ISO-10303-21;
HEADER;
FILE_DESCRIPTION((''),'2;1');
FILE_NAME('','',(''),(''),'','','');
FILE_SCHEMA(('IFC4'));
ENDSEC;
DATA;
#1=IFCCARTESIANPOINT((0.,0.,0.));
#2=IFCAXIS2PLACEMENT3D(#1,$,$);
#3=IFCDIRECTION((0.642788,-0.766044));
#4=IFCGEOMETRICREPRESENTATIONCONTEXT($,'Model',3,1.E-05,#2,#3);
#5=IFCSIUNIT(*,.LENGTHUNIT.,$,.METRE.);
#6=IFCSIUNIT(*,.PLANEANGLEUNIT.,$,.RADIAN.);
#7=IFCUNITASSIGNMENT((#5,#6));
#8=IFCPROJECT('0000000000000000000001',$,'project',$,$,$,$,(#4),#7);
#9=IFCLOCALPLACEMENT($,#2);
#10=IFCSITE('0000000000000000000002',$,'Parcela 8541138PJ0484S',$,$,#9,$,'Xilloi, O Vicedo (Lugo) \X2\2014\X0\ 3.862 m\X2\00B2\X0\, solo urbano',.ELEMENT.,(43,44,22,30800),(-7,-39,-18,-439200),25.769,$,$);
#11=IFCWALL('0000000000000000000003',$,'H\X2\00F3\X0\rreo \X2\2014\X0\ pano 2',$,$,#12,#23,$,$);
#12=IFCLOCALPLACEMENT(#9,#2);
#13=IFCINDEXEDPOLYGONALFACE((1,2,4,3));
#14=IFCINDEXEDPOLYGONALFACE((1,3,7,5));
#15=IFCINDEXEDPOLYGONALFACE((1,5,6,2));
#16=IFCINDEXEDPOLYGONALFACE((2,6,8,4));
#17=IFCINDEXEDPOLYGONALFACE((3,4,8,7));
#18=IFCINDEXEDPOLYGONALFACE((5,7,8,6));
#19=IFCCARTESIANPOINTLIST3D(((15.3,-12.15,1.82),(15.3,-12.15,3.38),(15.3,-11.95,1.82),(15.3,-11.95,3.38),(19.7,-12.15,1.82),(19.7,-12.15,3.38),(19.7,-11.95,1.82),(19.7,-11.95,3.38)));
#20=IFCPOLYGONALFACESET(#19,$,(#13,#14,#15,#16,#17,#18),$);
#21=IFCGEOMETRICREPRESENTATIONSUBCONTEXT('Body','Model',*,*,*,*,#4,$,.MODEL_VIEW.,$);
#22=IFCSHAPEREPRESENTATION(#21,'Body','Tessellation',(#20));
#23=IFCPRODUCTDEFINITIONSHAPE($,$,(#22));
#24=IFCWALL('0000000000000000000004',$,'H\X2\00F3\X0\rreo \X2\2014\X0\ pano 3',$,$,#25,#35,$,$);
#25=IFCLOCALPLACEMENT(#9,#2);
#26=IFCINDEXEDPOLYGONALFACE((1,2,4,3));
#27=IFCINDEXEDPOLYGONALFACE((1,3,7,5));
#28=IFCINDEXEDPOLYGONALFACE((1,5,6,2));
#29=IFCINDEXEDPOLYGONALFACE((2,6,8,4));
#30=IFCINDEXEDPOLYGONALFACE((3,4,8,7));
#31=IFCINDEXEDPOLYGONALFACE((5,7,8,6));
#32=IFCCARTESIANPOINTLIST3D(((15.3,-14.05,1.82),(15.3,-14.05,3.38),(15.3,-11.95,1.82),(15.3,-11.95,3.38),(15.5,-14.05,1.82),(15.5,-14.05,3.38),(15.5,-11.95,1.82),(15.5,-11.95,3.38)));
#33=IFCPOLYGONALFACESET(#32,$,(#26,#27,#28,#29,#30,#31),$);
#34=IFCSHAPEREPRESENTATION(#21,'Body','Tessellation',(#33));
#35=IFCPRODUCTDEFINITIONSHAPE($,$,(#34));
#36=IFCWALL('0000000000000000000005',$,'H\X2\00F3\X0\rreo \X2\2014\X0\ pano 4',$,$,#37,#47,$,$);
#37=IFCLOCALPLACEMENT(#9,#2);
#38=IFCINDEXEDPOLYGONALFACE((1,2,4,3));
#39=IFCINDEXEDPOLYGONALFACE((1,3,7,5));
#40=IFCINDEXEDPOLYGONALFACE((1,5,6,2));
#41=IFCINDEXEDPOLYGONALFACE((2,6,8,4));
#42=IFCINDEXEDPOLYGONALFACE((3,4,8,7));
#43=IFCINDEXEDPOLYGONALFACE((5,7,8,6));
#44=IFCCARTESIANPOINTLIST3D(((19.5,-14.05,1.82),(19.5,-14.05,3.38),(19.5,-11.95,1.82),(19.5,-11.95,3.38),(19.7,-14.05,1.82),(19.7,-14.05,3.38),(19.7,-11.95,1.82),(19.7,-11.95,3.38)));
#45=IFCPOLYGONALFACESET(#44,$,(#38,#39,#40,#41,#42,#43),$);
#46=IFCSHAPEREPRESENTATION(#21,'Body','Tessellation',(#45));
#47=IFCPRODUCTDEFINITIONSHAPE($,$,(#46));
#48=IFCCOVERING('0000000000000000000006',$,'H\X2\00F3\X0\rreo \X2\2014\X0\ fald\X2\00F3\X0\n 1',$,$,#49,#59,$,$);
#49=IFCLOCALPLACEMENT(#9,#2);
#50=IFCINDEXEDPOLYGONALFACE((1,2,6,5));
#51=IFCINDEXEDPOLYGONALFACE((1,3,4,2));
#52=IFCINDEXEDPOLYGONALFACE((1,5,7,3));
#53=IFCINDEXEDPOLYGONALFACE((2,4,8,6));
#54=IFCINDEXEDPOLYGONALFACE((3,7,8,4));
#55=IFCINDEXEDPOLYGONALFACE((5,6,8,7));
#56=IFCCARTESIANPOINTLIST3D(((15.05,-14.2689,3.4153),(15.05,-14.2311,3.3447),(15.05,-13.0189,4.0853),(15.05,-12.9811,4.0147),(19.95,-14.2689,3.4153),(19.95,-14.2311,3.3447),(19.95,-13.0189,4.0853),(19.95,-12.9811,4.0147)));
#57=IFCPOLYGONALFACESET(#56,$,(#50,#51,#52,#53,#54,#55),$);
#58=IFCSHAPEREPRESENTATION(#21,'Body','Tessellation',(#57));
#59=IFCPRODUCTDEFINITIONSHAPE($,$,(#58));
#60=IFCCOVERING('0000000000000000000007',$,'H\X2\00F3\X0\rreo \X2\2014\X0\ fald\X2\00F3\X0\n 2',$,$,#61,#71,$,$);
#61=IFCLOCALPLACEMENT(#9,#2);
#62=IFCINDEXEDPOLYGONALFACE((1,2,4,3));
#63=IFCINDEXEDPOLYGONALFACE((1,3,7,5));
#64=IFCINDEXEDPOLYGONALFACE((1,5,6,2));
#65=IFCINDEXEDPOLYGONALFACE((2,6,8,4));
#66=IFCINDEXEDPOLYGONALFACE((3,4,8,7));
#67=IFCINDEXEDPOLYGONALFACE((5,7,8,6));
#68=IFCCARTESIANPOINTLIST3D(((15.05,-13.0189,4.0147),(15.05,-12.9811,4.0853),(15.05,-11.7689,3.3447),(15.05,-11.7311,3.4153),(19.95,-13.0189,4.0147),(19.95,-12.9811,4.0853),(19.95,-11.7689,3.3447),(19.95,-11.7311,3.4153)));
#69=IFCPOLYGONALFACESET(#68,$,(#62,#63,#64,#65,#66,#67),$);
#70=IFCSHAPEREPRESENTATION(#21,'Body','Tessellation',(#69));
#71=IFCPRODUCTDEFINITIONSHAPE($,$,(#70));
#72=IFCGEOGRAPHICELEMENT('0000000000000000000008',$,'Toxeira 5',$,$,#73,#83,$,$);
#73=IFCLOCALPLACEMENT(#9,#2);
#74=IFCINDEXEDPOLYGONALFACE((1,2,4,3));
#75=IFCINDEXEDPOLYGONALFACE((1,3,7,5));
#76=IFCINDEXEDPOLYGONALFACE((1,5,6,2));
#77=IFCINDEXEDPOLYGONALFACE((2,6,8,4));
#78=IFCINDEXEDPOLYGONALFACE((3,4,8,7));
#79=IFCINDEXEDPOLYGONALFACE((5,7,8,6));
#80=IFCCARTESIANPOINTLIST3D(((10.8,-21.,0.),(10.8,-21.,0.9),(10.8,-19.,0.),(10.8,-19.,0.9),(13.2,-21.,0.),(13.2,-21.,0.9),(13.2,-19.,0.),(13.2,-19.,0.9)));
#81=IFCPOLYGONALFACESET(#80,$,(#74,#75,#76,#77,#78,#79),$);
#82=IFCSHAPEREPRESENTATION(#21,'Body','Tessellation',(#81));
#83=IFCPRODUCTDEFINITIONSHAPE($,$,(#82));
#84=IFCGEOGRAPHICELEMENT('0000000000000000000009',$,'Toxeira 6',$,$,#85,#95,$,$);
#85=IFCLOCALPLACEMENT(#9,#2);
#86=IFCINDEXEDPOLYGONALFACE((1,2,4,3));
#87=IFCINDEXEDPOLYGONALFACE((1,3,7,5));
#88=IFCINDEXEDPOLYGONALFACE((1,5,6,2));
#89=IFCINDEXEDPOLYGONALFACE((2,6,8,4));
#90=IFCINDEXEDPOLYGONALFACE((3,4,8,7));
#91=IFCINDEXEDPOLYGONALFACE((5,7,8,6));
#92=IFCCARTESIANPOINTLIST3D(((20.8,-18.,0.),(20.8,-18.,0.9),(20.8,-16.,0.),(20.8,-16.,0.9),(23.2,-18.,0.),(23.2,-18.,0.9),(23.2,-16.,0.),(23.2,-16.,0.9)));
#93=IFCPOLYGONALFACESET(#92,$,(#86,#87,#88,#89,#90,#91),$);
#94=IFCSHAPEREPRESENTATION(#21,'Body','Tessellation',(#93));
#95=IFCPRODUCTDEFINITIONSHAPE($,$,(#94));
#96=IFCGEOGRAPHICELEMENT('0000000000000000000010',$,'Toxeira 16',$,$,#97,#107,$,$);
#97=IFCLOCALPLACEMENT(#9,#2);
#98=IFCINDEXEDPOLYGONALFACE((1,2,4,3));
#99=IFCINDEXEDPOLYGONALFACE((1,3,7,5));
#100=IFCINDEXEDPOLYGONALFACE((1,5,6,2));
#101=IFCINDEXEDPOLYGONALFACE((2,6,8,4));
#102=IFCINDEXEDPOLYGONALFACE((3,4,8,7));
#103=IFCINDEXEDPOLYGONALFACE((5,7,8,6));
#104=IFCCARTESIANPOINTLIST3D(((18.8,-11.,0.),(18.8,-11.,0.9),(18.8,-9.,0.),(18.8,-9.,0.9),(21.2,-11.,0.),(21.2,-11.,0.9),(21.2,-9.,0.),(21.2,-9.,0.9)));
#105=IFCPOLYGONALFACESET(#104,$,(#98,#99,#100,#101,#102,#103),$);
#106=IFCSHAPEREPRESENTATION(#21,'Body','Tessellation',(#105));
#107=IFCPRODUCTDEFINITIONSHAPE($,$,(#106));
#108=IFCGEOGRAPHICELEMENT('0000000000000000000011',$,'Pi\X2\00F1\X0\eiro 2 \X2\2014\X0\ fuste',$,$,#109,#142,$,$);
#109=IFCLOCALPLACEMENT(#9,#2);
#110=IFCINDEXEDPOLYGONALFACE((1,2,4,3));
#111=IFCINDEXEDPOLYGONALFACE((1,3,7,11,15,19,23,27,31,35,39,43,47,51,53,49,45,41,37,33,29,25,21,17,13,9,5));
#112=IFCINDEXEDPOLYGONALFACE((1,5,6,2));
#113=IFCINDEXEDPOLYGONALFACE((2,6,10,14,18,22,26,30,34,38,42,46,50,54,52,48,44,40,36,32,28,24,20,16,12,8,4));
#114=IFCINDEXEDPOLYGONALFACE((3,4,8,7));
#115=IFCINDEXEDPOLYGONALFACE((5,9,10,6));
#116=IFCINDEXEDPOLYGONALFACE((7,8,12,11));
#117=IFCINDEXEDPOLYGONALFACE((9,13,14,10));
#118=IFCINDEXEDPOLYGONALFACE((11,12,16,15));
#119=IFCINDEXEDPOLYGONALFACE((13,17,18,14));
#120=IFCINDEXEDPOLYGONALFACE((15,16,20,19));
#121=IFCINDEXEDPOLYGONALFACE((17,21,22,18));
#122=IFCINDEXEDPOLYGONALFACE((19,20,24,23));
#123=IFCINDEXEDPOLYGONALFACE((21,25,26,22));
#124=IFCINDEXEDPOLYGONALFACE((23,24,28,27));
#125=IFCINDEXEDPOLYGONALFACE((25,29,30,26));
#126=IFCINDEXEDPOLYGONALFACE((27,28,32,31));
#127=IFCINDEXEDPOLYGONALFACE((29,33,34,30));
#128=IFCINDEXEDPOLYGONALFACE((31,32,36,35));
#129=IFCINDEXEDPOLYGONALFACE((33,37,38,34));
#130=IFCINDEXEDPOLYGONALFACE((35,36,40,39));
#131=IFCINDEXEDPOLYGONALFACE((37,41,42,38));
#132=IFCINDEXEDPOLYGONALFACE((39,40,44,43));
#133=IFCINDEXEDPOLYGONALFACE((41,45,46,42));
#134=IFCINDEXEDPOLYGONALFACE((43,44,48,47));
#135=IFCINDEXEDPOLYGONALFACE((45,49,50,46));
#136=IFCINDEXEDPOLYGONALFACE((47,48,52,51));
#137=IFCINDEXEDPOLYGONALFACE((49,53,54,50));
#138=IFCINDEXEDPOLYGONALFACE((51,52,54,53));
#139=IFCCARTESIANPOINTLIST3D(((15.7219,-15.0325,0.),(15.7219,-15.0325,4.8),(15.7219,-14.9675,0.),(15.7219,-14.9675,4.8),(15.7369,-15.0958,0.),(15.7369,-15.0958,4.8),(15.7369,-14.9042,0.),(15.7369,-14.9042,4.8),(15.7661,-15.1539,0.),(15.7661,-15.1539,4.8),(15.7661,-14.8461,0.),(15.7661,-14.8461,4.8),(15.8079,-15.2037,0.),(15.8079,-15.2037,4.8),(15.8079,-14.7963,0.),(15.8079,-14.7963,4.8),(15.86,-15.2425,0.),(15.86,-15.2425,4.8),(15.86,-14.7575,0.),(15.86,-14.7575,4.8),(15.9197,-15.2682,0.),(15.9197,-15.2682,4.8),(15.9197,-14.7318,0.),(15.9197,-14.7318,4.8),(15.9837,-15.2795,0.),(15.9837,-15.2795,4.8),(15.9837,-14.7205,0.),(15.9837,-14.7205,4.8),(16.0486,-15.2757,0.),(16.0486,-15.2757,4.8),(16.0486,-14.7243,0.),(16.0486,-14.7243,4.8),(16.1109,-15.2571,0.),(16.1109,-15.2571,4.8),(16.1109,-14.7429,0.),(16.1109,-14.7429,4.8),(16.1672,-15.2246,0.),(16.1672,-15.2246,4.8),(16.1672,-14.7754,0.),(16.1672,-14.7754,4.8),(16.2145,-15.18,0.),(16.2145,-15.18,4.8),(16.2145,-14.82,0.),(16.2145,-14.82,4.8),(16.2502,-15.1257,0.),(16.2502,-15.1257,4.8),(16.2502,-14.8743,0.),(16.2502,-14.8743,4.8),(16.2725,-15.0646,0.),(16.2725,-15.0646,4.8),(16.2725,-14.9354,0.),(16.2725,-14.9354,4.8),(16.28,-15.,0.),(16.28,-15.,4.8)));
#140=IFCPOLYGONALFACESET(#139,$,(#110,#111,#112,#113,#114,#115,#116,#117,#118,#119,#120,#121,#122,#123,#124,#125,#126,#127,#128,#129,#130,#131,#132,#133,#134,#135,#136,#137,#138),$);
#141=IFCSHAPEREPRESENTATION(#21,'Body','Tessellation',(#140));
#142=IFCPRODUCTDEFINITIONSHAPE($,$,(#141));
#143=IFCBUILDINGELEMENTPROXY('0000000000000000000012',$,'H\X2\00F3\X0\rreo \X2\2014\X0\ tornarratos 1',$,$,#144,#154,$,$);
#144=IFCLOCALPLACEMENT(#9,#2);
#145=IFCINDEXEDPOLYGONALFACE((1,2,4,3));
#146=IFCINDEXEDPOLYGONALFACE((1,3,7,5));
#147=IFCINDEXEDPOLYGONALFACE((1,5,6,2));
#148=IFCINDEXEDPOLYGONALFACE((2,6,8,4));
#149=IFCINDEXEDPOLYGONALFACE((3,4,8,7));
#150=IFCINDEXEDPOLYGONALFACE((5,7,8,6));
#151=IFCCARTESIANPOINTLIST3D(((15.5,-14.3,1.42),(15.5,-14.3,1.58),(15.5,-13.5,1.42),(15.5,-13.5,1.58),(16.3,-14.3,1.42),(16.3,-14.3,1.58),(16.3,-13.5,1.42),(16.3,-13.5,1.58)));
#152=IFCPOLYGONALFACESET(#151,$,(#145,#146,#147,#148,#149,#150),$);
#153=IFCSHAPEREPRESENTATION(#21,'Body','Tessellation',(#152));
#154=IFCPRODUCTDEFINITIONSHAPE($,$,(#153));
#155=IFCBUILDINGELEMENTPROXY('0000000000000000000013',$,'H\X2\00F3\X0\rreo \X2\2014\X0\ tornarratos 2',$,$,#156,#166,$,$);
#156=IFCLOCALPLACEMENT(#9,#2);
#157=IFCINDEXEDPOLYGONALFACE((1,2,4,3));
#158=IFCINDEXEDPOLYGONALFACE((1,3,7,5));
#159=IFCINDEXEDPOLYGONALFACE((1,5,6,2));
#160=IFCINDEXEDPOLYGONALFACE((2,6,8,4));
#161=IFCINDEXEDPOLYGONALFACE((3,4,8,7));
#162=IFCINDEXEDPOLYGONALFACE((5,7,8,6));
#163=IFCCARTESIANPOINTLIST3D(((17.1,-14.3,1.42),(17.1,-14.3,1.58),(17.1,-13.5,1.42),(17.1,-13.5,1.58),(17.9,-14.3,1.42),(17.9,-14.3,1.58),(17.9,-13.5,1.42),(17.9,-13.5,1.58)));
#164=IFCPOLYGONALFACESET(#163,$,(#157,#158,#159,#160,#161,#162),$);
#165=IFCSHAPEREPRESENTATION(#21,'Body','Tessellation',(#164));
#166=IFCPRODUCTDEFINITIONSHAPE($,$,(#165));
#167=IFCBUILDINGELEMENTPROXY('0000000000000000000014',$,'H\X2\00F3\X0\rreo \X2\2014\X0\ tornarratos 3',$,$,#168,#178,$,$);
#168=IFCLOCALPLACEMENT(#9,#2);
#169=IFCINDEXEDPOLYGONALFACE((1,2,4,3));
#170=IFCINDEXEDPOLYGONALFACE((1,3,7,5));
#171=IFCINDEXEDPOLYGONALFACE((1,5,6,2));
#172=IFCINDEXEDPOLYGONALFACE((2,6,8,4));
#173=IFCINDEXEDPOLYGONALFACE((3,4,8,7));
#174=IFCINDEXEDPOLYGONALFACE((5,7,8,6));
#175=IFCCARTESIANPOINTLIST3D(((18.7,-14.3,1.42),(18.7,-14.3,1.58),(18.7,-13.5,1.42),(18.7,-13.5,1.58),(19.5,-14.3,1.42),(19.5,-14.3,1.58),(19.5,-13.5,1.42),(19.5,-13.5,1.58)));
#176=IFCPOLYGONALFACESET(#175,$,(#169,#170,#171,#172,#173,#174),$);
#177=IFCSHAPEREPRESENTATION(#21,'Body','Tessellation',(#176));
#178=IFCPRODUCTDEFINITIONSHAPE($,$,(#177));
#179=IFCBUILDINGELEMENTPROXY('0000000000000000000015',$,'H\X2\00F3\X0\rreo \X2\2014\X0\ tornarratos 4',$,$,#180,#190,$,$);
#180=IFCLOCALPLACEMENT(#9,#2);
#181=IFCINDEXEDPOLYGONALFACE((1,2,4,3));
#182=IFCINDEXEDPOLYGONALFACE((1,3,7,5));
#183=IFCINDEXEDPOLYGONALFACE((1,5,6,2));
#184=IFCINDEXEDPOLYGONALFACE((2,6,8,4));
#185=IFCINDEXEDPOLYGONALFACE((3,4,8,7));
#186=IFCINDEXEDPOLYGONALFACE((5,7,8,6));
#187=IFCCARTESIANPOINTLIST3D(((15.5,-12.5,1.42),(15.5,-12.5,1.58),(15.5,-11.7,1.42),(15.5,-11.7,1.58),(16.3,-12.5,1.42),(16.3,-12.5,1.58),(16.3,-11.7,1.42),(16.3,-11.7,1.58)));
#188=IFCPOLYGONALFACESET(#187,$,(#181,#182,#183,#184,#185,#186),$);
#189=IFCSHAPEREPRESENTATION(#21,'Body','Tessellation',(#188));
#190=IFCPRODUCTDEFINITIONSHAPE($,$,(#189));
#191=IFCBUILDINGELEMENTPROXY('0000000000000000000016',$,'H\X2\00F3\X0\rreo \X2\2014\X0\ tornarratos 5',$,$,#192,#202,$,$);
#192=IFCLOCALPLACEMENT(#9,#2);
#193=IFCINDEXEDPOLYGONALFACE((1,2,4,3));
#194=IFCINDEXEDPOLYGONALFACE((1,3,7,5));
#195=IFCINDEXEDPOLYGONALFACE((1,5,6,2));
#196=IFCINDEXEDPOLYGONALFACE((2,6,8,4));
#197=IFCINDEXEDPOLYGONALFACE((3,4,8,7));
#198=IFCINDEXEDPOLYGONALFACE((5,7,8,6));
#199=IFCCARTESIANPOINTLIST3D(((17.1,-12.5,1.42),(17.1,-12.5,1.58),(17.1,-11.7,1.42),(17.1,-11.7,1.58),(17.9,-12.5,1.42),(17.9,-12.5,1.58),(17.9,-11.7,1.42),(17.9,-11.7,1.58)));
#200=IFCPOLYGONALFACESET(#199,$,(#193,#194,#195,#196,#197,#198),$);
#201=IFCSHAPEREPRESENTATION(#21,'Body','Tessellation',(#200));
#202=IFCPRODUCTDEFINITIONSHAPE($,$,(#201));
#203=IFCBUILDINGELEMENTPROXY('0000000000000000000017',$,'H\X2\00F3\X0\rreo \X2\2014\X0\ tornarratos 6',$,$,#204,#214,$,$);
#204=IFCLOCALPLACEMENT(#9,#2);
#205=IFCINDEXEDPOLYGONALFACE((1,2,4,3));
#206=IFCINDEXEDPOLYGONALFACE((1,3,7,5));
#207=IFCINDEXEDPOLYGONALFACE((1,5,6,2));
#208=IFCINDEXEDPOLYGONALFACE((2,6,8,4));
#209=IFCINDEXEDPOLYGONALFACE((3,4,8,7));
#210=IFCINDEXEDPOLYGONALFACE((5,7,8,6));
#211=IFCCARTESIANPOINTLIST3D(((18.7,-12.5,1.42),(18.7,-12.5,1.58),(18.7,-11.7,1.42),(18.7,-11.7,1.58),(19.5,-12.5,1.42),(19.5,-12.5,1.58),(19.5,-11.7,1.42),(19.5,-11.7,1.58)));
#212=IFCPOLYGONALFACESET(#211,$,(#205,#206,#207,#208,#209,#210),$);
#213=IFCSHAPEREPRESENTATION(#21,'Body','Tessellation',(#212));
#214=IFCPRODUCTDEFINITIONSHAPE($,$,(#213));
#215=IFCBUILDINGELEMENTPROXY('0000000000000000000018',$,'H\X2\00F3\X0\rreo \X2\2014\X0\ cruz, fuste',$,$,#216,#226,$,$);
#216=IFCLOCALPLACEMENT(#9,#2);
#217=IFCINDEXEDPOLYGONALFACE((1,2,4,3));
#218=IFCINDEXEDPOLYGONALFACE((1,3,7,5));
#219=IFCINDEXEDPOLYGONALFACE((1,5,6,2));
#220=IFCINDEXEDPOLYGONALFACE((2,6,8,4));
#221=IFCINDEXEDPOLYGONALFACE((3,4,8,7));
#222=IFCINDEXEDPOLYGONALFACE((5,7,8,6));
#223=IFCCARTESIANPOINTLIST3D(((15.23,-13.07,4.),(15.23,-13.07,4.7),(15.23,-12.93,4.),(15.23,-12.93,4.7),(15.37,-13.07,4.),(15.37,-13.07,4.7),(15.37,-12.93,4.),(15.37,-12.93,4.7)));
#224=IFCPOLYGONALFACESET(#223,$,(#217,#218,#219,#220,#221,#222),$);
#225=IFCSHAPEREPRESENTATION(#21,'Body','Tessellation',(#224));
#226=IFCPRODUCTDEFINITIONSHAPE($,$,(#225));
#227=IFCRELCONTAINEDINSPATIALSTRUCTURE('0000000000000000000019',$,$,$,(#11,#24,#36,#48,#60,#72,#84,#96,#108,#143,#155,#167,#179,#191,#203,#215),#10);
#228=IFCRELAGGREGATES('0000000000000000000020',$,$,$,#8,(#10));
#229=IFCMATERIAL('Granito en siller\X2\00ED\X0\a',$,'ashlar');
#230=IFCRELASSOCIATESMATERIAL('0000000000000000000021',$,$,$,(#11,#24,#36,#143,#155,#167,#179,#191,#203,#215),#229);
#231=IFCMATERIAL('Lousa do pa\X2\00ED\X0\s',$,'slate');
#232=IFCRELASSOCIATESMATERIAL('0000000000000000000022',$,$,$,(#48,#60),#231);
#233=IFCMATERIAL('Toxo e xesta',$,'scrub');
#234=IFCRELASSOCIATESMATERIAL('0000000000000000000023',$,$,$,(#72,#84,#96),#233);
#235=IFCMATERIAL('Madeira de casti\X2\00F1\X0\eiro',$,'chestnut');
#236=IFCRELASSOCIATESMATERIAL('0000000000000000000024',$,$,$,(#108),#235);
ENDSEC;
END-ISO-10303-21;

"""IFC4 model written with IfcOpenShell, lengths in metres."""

from ifc_helpers import new_model, si_unit, direction, frame, origin, origin_2d, place, context, subcontext, project, spatial, polyline, rectangle, circle, outline, extrude, material, element, save


model = new_model("IFC4")

# Units and contexts
model_context = context("Model", 3, precision=1e-05, world=origin(), true_north=direction((0.642788, -0.766044)))
body_context = subcontext(model_context, "Body", "Model", "MODEL_VIEW")
ifc_project = project(units=[si_unit("LENGTHUNIT", "METRE"), si_unit("PLANEANGLEUNIT", "RADIAN")], contexts=[model_context])

# Site
site_placement = place(None, origin())
site = spatial("IfcSite", under=ifc_project, at=site_placement, Name="Parcela 8541138PJ0484S", LongName="Xilloi, O Vicedo (Lugo) — 3.862 m², solo urbano", CompositionType="ELEMENT", RefLatitude=(43, 44, 22, 30800), RefLongitude=(-7, -39, -18, -439200), RefElevation=25.769)

# Shared definitions
ifc_material_1 = material(Name="Granito en sillería", Category="ashlar")

# Shared definitions
ifc_material_2 = material(Name="Madeira de castiñeiro", Category="chestnut")

# Walls
for number, where, name in (
    (1, (17.5, -12.05, 2.6), "Hórreo — pano 2"),
):
    element("IfcWall", number, at=place(site_placement, frame(where)), inside=site, material=ifc_material_1, Name=name, context=body_context, shape_type="SweptSolid", body=[
        extrude(rectangle(XDim=4.4, YDim=0.2, at=origin_2d()), frame((0.0, 0.0, -0.78)), (0.0, 0.0, 1.0), 1.56),
    ])
for number, where, name in (
    (2, (15.4, -13.0, 2.6), "Hórreo — pano 3"),
    (3, (19.6, -13.0, 2.6), "Hórreo — pano 4"),
):
    element("IfcWall", number, at=place(site_placement, frame(where)), inside=site, material=ifc_material_1, Name=name, context=body_context, shape_type="SweptSolid", body=[
        extrude(rectangle(XDim=0.2, YDim=2.1, at=origin_2d()), frame((0.0, 0.0, -0.78)), (0.0, 0.0, 1.0), 1.56),
    ])

# Coverings
ifc_material_3 = material(Name="Lousa do país", Category="slate")
covering_1_placement = place(site_placement, frame((17.5, -13.625, 3.715), z_axis=(0.0, -0.472417, 0.881375), x_axis=(1.0, 0.0, 0.0)))
element("IfcCovering", 4, at=covering_1_placement, inside=site, material=ifc_material_3, Name="Hórreo — faldón 1", context=body_context, shape_type="SweptSolid", body=[
    extrude(outline(polyline([(-2.45, -0.7091), (2.45, -0.7091), (2.45, 0.7091), (-2.45, 0.7091), (-2.45, -0.7091)])), frame((0.0, 0.0, -0.04)), (0.0, 0.0, 1.0), 0.08),
])
covering_2_placement = place(site_placement, frame((17.5, -12.375, 3.715), z_axis=(0.0, -0.472417, -0.881375), x_axis=(1.0, 0.0, 0.0)))
element("IfcCovering", 5, at=covering_2_placement, inside=site, material=ifc_material_3, Name="Hórreo — faldón 2", context=body_context, shape_type="SweptSolid", body=[
    extrude(outline(polyline([(-2.45, -0.7091), (2.45, -0.7091), (2.45, 0.7091), (-2.45, 0.7091), (-2.45, -0.7091)])), frame((0.0, 0.0, -0.04)), (0.0, 0.0, 1.0), 0.08),
])

# Geographic elements
ifc_material_4 = material(Name="Toxo e xesta", Category="scrub")
for number, where, name in (
    (6, (12.0, -20.0, 0.45), "Toxeira 5"),
    (7, (22.0, -17.0, 0.45), "Toxeira 6"),
    (8, (20.0, -10.0, 0.45), "Toxeira 16"),
):
    element("IfcGeographicElement", number, at=place(site_placement, frame(where)), inside=site, material=ifc_material_4, Name=name, context=body_context, shape_type="SweptSolid", body=[
        extrude(rectangle(XDim=2.4, YDim=2.0, at=origin_2d()), frame((0.0, 0.0, -0.45)), (0.0, 0.0, 1.0), 0.9),
    ])
geographic_element_placement = place(site_placement, frame((16.0, -15.0, 2.4)))
element("IfcGeographicElement", 9, at=geographic_element_placement, inside=site, material=ifc_material_2, Name="Piñeiro 2 — fuste", context=body_context, shape_type="SweptSolid", body=[
    extrude(circle(Radius=0.28, at=origin_2d()), frame((0.0, 0.0, -2.4)), (0.0, 0.0, 1.0), 4.8),
])

# Building element proxies
for number, where, name in (
    (10, (15.9, -13.9, 1.5), "Hórreo — tornarratos 1"),
    (11, (17.5, -13.9, 1.5), "Hórreo — tornarratos 2"),
    (12, (19.1, -13.9, 1.5), "Hórreo — tornarratos 3"),
    (13, (15.9, -12.1, 1.5), "Hórreo — tornarratos 4"),
    (14, (17.5, -12.1, 1.5), "Hórreo — tornarratos 5"),
    (15, (19.1, -12.1, 1.5), "Hórreo — tornarratos 6"),
):
    element("IfcBuildingElementProxy", number, at=place(site_placement, frame(where)), inside=site, material=ifc_material_1, Name=name, context=body_context, shape_type="SweptSolid", body=[
        extrude(rectangle(XDim=0.8, YDim=0.8, at=origin_2d()), frame((0.0, 0.0, -0.08)), (0.0, 0.0, 1.0), 0.16),
    ])
proxy_1_placement = place(site_placement, frame((15.3, -13.0, 4.35)))
element("IfcBuildingElementProxy", 16, at=proxy_1_placement, inside=site, material=ifc_material_1, Name="Hórreo — cruz, fuste", context=body_context, shape_type="SweptSolid", body=[
    extrude(rectangle(XDim=0.14, YDim=0.14, at=origin_2d()), frame((0.0, 0.0, -0.35)), (0.0, 0.0, 1.0), 0.7),
])

save(model, "model.ifc")
